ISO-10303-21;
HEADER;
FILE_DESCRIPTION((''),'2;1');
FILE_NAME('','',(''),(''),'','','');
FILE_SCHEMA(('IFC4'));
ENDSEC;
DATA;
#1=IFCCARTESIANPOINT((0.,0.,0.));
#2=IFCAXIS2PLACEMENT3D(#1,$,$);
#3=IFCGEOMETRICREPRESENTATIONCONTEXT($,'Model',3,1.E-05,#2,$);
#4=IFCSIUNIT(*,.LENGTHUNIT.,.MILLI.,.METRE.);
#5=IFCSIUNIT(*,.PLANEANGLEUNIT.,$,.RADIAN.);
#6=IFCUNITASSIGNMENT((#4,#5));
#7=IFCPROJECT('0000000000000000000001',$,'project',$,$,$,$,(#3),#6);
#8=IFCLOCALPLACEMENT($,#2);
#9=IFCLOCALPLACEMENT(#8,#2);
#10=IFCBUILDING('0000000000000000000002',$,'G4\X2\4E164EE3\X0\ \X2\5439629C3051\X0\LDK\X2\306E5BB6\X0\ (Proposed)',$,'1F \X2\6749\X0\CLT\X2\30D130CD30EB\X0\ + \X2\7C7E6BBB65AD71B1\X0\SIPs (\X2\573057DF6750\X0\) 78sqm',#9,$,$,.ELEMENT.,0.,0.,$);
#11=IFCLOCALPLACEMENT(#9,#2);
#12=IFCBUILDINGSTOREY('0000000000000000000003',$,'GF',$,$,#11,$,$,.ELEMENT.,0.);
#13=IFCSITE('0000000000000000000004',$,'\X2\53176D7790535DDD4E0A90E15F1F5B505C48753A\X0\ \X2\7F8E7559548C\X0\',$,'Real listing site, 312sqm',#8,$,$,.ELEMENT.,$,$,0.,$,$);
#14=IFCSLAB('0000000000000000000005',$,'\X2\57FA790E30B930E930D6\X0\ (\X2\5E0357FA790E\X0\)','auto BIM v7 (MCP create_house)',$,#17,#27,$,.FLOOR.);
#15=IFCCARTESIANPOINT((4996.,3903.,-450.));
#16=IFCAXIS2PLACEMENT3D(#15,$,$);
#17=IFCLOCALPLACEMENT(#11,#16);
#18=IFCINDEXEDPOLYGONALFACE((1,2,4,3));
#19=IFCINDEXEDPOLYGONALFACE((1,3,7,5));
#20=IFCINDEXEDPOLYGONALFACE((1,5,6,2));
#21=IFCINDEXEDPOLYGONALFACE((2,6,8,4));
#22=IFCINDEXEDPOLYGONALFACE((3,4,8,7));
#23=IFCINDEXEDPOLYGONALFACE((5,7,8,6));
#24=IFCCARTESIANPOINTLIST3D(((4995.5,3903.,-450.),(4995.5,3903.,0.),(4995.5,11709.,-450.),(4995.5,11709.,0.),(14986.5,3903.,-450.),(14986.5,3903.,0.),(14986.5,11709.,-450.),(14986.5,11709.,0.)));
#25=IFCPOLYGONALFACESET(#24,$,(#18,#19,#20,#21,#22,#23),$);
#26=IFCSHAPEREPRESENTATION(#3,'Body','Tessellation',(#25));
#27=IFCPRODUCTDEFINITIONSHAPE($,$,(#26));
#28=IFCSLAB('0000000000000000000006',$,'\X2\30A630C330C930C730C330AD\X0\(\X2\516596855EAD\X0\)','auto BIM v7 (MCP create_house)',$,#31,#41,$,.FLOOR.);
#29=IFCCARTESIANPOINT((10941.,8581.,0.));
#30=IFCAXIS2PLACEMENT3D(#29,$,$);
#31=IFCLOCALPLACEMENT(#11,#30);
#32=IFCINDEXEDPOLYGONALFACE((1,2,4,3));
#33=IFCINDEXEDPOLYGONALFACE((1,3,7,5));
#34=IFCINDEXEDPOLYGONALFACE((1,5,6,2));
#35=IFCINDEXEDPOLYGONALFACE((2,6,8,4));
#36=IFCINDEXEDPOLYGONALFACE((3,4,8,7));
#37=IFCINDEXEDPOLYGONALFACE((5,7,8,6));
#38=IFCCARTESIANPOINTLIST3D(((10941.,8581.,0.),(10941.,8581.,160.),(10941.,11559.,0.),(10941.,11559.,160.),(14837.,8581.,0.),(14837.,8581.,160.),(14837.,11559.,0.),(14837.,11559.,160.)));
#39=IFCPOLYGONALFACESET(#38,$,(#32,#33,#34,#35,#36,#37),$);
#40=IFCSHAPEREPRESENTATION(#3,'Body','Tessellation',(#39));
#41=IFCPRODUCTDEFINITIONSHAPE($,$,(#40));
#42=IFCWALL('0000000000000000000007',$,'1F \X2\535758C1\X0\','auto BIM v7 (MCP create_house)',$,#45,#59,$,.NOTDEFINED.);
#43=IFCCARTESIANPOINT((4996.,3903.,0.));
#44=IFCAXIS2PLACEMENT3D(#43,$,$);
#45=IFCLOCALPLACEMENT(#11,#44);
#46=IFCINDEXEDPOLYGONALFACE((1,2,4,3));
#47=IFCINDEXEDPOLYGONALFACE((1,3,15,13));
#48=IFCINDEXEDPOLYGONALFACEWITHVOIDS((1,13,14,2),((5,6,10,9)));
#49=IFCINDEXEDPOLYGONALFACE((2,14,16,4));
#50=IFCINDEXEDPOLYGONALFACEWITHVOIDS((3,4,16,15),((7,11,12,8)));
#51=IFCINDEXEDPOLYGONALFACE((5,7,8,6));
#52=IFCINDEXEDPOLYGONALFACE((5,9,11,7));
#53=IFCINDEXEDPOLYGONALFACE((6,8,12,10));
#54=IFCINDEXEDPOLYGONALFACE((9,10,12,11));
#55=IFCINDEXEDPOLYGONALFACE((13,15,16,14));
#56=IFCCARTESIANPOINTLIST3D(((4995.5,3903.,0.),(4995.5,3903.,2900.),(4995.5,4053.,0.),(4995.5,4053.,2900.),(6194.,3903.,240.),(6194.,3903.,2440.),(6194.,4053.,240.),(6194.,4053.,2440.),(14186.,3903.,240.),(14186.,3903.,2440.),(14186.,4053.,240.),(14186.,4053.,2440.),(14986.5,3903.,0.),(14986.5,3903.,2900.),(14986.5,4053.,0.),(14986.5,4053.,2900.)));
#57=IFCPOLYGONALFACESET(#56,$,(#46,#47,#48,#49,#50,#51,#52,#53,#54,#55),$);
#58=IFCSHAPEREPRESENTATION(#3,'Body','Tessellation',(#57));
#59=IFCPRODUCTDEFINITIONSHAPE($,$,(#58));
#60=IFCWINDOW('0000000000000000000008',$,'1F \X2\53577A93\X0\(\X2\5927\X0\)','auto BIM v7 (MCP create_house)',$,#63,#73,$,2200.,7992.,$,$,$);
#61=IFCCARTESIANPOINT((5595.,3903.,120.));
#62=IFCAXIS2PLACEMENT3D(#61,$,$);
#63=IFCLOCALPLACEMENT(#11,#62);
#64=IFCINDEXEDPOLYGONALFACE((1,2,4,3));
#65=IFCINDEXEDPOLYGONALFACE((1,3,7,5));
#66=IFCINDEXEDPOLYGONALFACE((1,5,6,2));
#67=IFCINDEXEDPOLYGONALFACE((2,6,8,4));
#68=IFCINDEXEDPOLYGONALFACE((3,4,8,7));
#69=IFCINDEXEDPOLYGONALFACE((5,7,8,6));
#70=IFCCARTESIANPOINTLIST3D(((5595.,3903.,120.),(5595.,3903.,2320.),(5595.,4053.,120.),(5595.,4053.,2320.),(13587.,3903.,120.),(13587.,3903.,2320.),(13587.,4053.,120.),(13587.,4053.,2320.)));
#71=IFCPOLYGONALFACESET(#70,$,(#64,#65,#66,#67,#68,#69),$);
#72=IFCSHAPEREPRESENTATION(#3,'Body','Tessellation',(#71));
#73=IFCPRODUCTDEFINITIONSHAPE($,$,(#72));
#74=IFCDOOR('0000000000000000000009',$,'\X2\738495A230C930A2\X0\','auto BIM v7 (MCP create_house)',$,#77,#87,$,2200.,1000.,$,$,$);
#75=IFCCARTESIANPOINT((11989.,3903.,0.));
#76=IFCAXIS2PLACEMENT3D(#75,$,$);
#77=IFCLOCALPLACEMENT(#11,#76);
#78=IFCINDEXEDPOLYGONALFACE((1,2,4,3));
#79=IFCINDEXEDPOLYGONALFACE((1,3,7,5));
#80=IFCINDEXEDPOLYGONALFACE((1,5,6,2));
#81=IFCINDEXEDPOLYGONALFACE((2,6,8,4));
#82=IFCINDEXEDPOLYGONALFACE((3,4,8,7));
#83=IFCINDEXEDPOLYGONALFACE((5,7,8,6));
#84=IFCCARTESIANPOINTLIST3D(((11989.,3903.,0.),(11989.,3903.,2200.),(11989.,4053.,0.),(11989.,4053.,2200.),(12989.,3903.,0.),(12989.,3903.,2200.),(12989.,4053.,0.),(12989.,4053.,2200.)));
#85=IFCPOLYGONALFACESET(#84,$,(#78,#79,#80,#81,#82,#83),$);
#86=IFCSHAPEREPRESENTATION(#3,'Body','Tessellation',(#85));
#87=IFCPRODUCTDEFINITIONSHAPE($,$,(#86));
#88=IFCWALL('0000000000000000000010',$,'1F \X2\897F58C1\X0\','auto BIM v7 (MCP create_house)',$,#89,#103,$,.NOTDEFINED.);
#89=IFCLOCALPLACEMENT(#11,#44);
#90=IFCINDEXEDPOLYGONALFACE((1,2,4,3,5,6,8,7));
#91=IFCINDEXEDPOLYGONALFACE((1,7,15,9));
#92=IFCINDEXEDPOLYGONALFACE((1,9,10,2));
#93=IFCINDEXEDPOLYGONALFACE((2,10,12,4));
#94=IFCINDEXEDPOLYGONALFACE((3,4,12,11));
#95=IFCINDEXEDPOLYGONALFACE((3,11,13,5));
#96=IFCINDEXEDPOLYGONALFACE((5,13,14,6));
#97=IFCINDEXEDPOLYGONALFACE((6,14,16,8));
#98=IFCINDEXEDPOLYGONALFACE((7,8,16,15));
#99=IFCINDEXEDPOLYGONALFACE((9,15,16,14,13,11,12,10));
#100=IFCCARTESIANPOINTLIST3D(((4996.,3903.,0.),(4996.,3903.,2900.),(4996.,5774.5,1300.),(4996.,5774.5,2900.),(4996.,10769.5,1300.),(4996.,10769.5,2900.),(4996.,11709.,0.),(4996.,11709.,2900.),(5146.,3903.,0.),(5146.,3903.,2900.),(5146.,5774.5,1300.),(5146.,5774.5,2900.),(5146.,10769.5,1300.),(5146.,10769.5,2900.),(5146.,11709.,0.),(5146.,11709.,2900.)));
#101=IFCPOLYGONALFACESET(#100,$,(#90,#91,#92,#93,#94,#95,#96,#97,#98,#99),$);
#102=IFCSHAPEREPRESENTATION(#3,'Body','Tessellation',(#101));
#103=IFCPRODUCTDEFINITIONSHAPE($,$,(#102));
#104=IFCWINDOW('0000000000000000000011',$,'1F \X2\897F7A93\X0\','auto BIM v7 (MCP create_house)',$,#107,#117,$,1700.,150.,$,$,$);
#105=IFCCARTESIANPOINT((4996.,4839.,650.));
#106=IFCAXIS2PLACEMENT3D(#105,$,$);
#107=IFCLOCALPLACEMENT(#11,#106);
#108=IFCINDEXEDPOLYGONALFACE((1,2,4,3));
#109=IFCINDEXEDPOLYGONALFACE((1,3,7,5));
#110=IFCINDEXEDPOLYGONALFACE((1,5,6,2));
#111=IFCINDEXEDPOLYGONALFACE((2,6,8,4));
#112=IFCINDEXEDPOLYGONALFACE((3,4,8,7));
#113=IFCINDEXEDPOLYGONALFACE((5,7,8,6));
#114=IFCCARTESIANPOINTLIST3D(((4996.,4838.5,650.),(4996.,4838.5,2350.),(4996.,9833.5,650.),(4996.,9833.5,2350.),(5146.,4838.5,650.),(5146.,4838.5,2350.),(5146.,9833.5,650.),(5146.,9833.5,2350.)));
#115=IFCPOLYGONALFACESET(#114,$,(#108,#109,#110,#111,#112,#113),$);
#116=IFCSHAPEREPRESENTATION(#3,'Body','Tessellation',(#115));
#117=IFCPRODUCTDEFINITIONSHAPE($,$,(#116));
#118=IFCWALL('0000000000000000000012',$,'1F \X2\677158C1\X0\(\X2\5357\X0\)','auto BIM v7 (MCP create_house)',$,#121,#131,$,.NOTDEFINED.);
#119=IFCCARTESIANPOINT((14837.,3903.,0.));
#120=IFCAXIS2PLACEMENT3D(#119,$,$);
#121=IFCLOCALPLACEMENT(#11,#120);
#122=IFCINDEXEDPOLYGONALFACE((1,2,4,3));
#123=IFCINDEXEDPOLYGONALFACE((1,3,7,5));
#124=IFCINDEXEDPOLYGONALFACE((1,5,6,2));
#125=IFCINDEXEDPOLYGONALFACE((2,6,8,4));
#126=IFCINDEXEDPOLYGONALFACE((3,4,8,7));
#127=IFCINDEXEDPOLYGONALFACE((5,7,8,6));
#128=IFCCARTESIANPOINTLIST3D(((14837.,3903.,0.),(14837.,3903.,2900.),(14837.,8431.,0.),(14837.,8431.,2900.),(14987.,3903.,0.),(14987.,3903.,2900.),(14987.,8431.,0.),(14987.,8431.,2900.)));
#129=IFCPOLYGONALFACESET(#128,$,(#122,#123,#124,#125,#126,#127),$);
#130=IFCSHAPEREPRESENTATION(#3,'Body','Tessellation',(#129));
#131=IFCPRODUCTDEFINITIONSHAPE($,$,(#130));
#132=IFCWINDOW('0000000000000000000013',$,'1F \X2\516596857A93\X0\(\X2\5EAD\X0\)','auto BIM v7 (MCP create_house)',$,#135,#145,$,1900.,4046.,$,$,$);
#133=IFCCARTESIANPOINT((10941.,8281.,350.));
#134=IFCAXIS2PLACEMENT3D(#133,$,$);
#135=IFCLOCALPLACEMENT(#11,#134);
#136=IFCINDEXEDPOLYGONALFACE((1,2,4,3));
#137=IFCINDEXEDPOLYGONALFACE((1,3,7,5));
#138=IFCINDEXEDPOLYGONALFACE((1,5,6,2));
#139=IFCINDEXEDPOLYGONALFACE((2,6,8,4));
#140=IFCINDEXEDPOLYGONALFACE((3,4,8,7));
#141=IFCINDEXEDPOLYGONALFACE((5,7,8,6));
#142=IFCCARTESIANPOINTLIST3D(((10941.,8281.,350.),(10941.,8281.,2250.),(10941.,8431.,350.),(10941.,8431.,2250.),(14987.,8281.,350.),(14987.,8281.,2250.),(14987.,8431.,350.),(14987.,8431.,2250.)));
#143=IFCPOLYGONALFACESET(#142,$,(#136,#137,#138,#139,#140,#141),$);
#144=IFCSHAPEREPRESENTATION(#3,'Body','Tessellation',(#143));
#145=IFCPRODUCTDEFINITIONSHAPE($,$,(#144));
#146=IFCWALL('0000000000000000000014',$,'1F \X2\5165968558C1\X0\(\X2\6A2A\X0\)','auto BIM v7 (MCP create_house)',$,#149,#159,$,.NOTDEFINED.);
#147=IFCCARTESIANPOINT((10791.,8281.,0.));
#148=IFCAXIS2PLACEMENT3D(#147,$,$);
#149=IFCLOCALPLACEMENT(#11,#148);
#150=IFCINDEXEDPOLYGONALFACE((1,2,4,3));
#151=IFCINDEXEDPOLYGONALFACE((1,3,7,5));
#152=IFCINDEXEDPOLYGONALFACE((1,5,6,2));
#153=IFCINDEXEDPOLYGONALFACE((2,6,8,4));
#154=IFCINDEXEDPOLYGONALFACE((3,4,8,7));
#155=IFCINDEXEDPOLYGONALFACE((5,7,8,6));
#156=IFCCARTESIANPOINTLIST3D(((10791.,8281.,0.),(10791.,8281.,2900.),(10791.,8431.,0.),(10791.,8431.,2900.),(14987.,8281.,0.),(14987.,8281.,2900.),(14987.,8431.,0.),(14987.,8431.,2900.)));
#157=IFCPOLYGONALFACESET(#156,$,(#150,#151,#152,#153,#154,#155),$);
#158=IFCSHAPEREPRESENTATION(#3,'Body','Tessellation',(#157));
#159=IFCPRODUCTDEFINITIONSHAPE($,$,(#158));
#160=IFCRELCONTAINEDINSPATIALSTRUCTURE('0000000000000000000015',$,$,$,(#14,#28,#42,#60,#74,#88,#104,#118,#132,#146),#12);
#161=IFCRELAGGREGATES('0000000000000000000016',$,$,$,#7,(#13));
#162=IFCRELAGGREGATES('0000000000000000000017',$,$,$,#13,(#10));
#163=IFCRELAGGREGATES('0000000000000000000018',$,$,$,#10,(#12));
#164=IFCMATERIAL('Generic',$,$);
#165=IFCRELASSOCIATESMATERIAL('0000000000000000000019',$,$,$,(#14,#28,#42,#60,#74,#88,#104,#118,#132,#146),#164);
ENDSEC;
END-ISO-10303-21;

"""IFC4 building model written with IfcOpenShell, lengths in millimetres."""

from ifc_helpers import new_model, si_unit, frame, frame_2d, origin, place, context, project, spatial, rectangle, extrude, material, element, fill, save


model = new_model("IFC4")

# Units and contexts
model_context = context("Model", 3, precision=1e-05, world=origin())
ifc_project = project(units=[si_unit("LENGTHUNIT", "METRE", prefix="MILLI"), si_unit("PLANEANGLEUNIT", "RADIAN")], contexts=[model_context])

# Site, building, storey
site_placement = place(None, origin())
site = spatial("IfcSite", under=ifc_project, at=site_placement, Name="北海道川上郡弟子屈町 美留和", ObjectType="Real listing site, 312sqm", CompositionType="ELEMENT", RefElevation=0.0)
building_placement = place(site_placement, origin())
building = spatial("IfcBuilding", under=site, at=building_placement, Name="G4世代 吹抜けLDKの家 (Proposed)", ObjectType="1F 杉CLTパネル + 籾殻断熱SIPs (地域材) 78sqm", CompositionType="ELEMENT", ElevationOfRefHeight=0.0, ElevationOfTerrain=0.0)
storey_placement = place(building_placement, origin())
storey = spatial("IfcBuildingStorey", under=building, at=storey_placement, Name="GF", CompositionType="ELEMENT", Elevation=0.0)

# Slabs
ifc_material = material(Name="Generic")
slab_1_placement = place(storey_placement, frame((4996.0, 3903.0, -450.0)))
element("IfcSlab", 1, at=slab_1_placement, inside=storey, material=ifc_material, Name="基礎スラブ (布基礎)", Description="auto BIM v7 (MCP create_house)", PredefinedType="FLOOR", context=model_context, shape_type="SweptSolid", body=[
    extrude(rectangle(XDim=9991.0, YDim=7806.0, at=frame_2d((4995.0, 3903.0))), frame((4996.0, 3903.0, -450.0)), (0.0, 0.0, 1.0), 450.0),
])
slab_2_placement = place(storey_placement, frame((10941.0, 8581.0, 0.0)))
element("IfcSlab", 2, at=slab_2_placement, inside=storey, material=ifc_material, Name="ウッドデッキ(入隅庭)", Description="auto BIM v7 (MCP create_house)", PredefinedType="FLOOR", context=model_context, shape_type="SweptSolid", body=[
    extrude(rectangle(XDim=3896.0, YDim=2978.0, at=frame_2d((1948.0, 1489.0))), frame((10941.0, 8581.0, 0.0)), (0.0, 0.0, 1.0), 160.0),
])

# Wall, openings, window, door
wall_1_placement = place(storey_placement, frame((4996.0, 3903.0, 0.0)))
wall_1 = element("IfcWall", 3, at=wall_1_placement, inside=storey, material=ifc_material, Name="1F 南壁", Description="auto BIM v7 (MCP create_house)", PredefinedType="NOTDEFINED", context=model_context, shape_type="SweptSolid", body=[
    extrude(rectangle(XDim=9991.0, YDim=150.0, at=frame_2d((4995.0, 75.0))), frame((4996.0, 3903.0, 0.0)), (0.0, 0.0, 1.0), 2900.0),
])
opening_1_placement = place(storey_placement, frame((5595.0, 3903.0, 120.0)))
opening_1 = element("IfcOpeningElement", 4, at=opening_1_placement, cuts=wall_1, PredefinedType="NOTDEFINED", context=model_context, shape_type="SweptSolid", body=[
    extrude(rectangle(XDim=7992.0, YDim=150.0, at=frame_2d((3996.0, 75.0))), frame((5595.0, 3903.0, 120.0)), (0.0, 0.0, 1.0), 2200.0),
])
opening_2_placement = place(storey_placement, frame((11989.0, 3903.0, 0.0)))
opening_2 = element("IfcOpeningElement", 5, at=opening_2_placement, cuts=wall_1, PredefinedType="NOTDEFINED", context=model_context, shape_type="SweptSolid", body=[
    extrude(rectangle(XDim=1000.0, YDim=150.0, at=frame_2d((500.0, 75.0))), frame((11989.0, 3903.0, 0.0)), (0.0, 0.0, 1.0), 2200.0),
])
window_1_placement = place(storey_placement, frame((5595.0, 3903.0, 120.0)))
window_1 = element("IfcWindow", 6, at=window_1_placement, inside=storey, material=ifc_material, Name="1F 南窓(大)", Description="auto BIM v7 (MCP create_house)", OverallHeight=2200.0, OverallWidth=7992.0, context=model_context, shape_type="SweptSolid", body=[
    extrude(rectangle(XDim=7992.0, YDim=150.0, at=frame_2d((3996.0, 75.0))), frame((5595.0, 3903.0, 120.0)), (0.0, 0.0, 1.0), 2200.0),
])
fill(opening_1, window_1)
door_placement = place(storey_placement, frame((11989.0, 3903.0, 0.0)))
door = element("IfcDoor", 7, at=door_placement, inside=storey, material=ifc_material, Name="玄関ドア", Description="auto BIM v7 (MCP create_house)", OverallHeight=2200.0, OverallWidth=1000.0, context=model_context, shape_type="SweptSolid", body=[
    extrude(rectangle(XDim=1000.0, YDim=150.0, at=frame_2d((500.0, 75.0))), frame((11989.0, 3903.0, 0.0)), (0.0, 0.0, 1.0), 2200.0),
])
fill(opening_2, door)

# Wall, opening, window
wall_2_placement = place(storey_placement, frame((4996.0, 3903.0, 0.0)))
wall_2 = element("IfcWall", 8, at=wall_2_placement, inside=storey, material=ifc_material, Name="1F 西壁", Description="auto BIM v7 (MCP create_house)", PredefinedType="NOTDEFINED", context=model_context, shape_type="SweptSolid", body=[
    extrude(rectangle(XDim=150.0, YDim=7806.0, at=frame_2d((75.0, 3903.0))), frame((4996.0, 3903.0, 0.0)), (0.0, 0.0, 1.0), 2900.0),
])
opening_3_placement = place(storey_placement, frame((4996.0, 4839.0, 650.0)))
opening_3 = element("IfcOpeningElement", 9, at=opening_3_placement, cuts=wall_2, PredefinedType="NOTDEFINED", context=model_context, shape_type="SweptSolid", body=[
    extrude(rectangle(XDim=150.0, YDim=4995.0, at=frame_2d((75.0, 2497.0))), frame((4996.0, 4839.0, 650.0)), (0.0, 0.0, 1.0), 1700.0),
])
window_2_placement = place(storey_placement, frame((4996.0, 4839.0, 650.0)))
window_2 = element("IfcWindow", 10, at=window_2_placement, inside=storey, material=ifc_material, Name="1F 西窓", Description="auto BIM v7 (MCP create_house)", OverallHeight=1700.0, OverallWidth=150.0, context=model_context, shape_type="SweptSolid", body=[
    extrude(rectangle(XDim=150.0, YDim=4995.0, at=frame_2d((75.0, 2497.0))), frame((4996.0, 4839.0, 650.0)), (0.0, 0.0, 1.0), 1700.0),
])
fill(opening_3, window_2)

# Wall, opening, window
wall_3_placement = place(storey_placement, frame((14837.0, 3903.0, 0.0)))
wall_3 = element("IfcWall", 11, at=wall_3_placement, inside=storey, material=ifc_material, Name="1F 東壁(南)", Description="auto BIM v7 (MCP create_house)", PredefinedType="NOTDEFINED", context=model_context, shape_type="SweptSolid", body=[
    extrude(rectangle(XDim=150.0, YDim=4528.0, at=frame_2d((75.0, 2264.0))), frame((14837.0, 3903.0, 0.0)), (0.0, 0.0, 1.0), 2900.0),
])
opening_4_placement = place(storey_placement, frame((10941.0, 8281.0, 350.0)))
opening_4 = element("IfcOpeningElement", 12, at=opening_4_placement, cuts=wall_3, PredefinedType="NOTDEFINED", context=model_context, shape_type="SweptSolid", body=[
    extrude(rectangle(XDim=4046.0, YDim=150.0, at=frame_2d((2023.0, 75.0))), frame((10941.0, 8281.0, 350.0)), (0.0, 0.0, 1.0), 1900.0),
])
window_3_placement = place(storey_placement, frame((10941.0, 8281.0, 350.0)))
window_3 = element("IfcWindow", 13, at=window_3_placement, inside=storey, material=ifc_material, Name="1F 入隅窓(庭)", Description="auto BIM v7 (MCP create_house)", OverallHeight=1900.0, OverallWidth=4046.0, context=model_context, shape_type="SweptSolid", body=[
    extrude(rectangle(XDim=4046.0, YDim=150.0, at=frame_2d((2023.0, 75.0))), frame((10941.0, 8281.0, 350.0)), (0.0, 0.0, 1.0), 1900.0),
])
fill(opening_4, window_3)

# Wall
wall_4_placement = place(storey_placement, frame((10791.0, 8281.0, 0.0)))
element("IfcWall", 14, at=wall_4_placement, inside=storey, material=ifc_material, Name="1F 入隅壁(横)", Description="auto BIM v7 (MCP create_house)", PredefinedType="NOTDEFINED", context=model_context, shape_type="SweptSolid", body=[
    extrude(rectangle(XDim=4196.0, YDim=150.0, at=frame_2d((2098.0, 75.0))), frame((10791.0, 8281.0, 0.0)), (0.0, 0.0, 1.0), 2900.0),
])

save(model, "model.ifc")
